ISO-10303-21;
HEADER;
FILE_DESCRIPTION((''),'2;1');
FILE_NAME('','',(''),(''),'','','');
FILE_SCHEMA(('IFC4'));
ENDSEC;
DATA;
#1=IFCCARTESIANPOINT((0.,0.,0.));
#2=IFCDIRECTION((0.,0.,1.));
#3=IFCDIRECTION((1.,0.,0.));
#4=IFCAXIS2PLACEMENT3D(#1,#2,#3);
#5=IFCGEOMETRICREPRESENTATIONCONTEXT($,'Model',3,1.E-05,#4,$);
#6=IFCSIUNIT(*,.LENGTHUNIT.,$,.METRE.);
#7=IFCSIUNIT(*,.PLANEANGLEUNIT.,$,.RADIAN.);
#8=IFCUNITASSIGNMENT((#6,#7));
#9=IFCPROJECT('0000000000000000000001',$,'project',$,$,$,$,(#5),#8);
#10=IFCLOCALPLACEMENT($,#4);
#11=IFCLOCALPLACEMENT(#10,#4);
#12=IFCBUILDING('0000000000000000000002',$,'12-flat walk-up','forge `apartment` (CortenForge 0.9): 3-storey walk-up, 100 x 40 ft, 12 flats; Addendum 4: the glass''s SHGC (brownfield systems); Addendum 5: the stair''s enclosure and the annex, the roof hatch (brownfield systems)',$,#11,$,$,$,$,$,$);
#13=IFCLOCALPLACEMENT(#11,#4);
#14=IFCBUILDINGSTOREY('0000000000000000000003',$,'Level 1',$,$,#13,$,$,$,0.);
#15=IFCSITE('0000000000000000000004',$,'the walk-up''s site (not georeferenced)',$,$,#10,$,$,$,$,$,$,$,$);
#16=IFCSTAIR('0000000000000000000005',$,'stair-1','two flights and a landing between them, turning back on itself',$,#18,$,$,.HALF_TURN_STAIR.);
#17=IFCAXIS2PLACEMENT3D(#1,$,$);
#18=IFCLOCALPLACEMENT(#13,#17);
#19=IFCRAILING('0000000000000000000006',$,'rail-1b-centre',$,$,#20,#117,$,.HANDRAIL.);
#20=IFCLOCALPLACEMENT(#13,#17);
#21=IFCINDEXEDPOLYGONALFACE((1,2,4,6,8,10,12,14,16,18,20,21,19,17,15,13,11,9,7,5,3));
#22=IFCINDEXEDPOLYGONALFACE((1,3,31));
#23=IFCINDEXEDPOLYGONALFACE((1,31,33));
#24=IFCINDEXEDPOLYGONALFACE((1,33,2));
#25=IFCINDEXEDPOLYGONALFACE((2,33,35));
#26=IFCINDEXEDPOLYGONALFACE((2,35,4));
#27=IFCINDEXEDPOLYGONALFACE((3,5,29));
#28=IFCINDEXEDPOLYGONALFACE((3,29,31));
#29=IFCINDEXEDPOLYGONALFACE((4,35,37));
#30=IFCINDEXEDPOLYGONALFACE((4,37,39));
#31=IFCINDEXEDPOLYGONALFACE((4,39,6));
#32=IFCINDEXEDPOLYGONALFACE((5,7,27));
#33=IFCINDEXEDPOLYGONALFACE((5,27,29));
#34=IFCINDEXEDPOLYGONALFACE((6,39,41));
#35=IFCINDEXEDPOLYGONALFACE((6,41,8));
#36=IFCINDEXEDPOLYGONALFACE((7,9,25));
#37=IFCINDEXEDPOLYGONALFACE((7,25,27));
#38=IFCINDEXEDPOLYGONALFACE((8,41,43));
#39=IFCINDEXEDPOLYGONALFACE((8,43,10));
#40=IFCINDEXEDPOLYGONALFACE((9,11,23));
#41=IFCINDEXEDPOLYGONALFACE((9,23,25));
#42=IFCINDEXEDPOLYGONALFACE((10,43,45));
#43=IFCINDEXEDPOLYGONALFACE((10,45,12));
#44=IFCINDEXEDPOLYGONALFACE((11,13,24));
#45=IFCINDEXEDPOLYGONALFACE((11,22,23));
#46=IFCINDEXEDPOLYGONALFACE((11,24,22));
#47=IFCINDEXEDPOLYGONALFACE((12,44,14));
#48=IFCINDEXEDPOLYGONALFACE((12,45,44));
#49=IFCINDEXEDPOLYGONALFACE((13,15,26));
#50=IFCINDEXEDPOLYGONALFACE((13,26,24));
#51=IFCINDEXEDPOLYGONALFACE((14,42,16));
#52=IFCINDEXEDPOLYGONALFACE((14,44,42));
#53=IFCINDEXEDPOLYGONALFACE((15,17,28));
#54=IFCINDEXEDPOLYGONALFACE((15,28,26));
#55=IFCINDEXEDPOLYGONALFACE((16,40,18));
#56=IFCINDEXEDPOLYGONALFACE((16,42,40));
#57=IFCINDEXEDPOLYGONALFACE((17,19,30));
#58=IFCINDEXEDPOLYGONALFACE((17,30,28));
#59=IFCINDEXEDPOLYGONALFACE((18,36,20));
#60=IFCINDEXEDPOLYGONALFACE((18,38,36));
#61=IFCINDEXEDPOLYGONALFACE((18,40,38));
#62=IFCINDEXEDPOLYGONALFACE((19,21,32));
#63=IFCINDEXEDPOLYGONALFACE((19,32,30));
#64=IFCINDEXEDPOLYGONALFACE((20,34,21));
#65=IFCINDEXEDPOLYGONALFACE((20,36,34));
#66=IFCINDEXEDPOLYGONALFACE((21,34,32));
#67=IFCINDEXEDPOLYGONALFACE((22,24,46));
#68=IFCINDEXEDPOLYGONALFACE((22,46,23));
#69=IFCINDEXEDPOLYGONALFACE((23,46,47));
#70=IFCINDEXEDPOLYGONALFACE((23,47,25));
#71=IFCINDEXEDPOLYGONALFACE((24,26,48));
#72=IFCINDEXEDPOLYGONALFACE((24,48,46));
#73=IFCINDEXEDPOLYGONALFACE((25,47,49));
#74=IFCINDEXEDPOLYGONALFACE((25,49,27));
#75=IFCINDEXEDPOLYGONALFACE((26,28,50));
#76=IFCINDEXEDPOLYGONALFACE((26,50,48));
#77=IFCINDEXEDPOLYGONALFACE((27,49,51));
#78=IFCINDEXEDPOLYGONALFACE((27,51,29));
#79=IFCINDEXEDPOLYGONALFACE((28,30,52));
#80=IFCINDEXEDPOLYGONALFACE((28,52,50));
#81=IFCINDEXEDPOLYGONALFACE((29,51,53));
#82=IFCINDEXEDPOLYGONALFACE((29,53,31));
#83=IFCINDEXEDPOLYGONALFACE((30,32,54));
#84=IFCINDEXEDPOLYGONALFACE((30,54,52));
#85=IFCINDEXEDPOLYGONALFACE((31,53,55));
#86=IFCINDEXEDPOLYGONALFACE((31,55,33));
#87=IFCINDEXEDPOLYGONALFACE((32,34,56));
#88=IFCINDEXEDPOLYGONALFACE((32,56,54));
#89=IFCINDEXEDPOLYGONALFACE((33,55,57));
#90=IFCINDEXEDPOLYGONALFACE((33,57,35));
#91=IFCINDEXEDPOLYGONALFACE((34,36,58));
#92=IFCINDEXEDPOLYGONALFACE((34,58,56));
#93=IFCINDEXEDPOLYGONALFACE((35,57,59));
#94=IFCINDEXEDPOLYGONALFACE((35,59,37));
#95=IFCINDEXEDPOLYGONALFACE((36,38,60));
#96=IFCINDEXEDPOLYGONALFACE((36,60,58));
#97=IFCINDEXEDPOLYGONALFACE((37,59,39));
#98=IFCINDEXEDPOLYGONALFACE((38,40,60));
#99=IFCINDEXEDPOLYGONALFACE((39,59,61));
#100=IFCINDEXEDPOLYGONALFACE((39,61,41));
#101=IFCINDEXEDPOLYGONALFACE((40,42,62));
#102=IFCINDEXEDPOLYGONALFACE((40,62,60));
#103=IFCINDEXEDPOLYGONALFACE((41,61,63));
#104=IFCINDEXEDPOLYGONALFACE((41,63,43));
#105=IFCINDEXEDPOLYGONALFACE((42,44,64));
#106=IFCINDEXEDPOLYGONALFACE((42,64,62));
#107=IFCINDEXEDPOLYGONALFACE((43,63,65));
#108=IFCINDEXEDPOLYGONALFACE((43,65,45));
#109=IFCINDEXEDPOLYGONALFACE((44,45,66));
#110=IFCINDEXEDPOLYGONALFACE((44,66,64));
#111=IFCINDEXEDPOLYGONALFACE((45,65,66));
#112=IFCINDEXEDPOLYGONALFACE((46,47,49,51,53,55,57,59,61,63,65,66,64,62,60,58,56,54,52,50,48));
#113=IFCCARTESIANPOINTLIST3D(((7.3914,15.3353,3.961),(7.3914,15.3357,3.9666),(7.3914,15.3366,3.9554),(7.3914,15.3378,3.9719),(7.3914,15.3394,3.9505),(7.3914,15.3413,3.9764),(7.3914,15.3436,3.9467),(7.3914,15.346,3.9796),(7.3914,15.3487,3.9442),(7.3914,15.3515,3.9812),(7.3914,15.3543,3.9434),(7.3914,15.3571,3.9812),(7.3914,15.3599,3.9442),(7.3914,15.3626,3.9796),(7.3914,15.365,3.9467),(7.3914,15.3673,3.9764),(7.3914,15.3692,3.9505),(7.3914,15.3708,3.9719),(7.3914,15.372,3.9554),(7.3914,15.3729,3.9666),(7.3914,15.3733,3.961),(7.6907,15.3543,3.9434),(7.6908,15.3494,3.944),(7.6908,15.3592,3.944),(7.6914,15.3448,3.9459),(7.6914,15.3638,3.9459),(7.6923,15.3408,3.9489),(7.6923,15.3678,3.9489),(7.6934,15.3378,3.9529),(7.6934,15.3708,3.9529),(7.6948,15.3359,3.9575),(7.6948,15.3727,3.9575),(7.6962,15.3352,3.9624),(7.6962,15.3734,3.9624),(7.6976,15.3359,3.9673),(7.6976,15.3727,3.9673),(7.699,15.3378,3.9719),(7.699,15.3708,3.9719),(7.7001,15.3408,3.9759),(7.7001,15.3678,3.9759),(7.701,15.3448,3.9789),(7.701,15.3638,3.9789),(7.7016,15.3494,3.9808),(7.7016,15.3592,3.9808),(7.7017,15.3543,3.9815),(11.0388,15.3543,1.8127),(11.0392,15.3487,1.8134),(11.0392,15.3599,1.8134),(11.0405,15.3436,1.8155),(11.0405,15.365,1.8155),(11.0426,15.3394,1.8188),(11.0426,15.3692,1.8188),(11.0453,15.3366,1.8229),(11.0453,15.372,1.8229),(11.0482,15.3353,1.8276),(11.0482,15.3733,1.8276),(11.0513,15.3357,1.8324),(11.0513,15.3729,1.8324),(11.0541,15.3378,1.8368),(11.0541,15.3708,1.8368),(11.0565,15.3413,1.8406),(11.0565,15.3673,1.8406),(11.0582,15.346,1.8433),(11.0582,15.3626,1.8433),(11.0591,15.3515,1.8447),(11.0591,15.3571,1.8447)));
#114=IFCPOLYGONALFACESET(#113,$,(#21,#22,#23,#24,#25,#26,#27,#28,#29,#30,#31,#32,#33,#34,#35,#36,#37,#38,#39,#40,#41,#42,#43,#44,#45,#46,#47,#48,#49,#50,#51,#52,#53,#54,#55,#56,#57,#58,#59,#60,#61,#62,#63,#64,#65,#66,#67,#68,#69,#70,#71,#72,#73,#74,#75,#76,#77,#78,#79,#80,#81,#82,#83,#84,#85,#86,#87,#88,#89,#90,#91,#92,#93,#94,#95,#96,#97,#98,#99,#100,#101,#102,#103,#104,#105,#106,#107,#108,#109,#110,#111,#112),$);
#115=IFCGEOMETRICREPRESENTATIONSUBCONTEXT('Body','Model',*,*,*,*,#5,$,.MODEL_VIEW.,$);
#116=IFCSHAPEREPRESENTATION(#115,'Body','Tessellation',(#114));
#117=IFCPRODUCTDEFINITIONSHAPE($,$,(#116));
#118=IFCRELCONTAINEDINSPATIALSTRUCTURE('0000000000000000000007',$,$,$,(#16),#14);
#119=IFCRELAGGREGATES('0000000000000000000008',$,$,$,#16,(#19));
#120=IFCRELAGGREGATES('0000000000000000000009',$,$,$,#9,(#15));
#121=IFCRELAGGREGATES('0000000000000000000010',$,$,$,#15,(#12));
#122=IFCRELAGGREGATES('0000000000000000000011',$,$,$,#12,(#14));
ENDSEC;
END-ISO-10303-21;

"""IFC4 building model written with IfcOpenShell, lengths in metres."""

from ifc_helpers import new_model, entity, si_unit, frame, origin_with_axes, place, context, subcontext, project, spatial, element, aggregate, save


model = new_model("IFC4")

# Units and contexts
model_context = context("Model", 3, precision=1e-05, world=origin_with_axes())
body_context = subcontext(model_context, "Body", "Model", "MODEL_VIEW")
ifc_project = project(units=[si_unit("LENGTHUNIT", "METRE"), si_unit("PLANEANGLEUNIT", "RADIAN")], contexts=[model_context])

# Site, building, storey
site_placement = place(None, origin_with_axes())
site = spatial("IfcSite", under=ifc_project, at=site_placement, Name="the walk-up's site (not georeferenced)")
building_placement = place(site_placement, origin_with_axes())
building = spatial("IfcBuilding", under=site, at=building_placement, Name="12-flat walk-up", Description="forge `apartment` (CortenForge 0.9): 3-storey walk-up, 100 x 40 ft, 12 flats; Addendum 4: the glass's SHGC (brownfield systems); Addendum 5: the stair's enclosure and the annex, the roof hatch (brownfield systems)")
storey_placement = place(building_placement, origin_with_axes())
storey = spatial("IfcBuildingStorey", under=building, at=storey_placement, Name="Level 1", Elevation=0.0)

# Stair, railing
stair_placement = place(storey_placement, origin_with_axes())
stair = element("IfcStair", 1, at=stair_placement, inside=storey, Name="stair-1", Description="two flights and a landing between them, turning back on itself", PredefinedType="HALF_TURN_STAIR")
railing_1_placement = place(stair_placement, frame((11.049, 15.3543, 1.8288), z_axis=(0.0, 0.0, 1.0), x_axis=(1.0, 0.0, 0.0)))
railing_1 = element("IfcRailing", 2, at=railing_1_placement, Name="rail-1b-centre", PredefinedType="HANDRAIL", context=body_context, shape_type="AdvancedSweptSolid", body=[
    entity("IfcSweptDiskSolid", entity("IfcPolyline", [entity("IfcCartesianPoint", [0.0, 0.0, 0.0]), entity("IfcCartesianPoint", [-3.3528, 0.0, 2.1336]), entity("IfcCartesianPoint", [-3.6576, 0.0, 2.1336])]), 0.0191),
])
aggregate(stair, [railing_1])

save(model, "model.ifc")
